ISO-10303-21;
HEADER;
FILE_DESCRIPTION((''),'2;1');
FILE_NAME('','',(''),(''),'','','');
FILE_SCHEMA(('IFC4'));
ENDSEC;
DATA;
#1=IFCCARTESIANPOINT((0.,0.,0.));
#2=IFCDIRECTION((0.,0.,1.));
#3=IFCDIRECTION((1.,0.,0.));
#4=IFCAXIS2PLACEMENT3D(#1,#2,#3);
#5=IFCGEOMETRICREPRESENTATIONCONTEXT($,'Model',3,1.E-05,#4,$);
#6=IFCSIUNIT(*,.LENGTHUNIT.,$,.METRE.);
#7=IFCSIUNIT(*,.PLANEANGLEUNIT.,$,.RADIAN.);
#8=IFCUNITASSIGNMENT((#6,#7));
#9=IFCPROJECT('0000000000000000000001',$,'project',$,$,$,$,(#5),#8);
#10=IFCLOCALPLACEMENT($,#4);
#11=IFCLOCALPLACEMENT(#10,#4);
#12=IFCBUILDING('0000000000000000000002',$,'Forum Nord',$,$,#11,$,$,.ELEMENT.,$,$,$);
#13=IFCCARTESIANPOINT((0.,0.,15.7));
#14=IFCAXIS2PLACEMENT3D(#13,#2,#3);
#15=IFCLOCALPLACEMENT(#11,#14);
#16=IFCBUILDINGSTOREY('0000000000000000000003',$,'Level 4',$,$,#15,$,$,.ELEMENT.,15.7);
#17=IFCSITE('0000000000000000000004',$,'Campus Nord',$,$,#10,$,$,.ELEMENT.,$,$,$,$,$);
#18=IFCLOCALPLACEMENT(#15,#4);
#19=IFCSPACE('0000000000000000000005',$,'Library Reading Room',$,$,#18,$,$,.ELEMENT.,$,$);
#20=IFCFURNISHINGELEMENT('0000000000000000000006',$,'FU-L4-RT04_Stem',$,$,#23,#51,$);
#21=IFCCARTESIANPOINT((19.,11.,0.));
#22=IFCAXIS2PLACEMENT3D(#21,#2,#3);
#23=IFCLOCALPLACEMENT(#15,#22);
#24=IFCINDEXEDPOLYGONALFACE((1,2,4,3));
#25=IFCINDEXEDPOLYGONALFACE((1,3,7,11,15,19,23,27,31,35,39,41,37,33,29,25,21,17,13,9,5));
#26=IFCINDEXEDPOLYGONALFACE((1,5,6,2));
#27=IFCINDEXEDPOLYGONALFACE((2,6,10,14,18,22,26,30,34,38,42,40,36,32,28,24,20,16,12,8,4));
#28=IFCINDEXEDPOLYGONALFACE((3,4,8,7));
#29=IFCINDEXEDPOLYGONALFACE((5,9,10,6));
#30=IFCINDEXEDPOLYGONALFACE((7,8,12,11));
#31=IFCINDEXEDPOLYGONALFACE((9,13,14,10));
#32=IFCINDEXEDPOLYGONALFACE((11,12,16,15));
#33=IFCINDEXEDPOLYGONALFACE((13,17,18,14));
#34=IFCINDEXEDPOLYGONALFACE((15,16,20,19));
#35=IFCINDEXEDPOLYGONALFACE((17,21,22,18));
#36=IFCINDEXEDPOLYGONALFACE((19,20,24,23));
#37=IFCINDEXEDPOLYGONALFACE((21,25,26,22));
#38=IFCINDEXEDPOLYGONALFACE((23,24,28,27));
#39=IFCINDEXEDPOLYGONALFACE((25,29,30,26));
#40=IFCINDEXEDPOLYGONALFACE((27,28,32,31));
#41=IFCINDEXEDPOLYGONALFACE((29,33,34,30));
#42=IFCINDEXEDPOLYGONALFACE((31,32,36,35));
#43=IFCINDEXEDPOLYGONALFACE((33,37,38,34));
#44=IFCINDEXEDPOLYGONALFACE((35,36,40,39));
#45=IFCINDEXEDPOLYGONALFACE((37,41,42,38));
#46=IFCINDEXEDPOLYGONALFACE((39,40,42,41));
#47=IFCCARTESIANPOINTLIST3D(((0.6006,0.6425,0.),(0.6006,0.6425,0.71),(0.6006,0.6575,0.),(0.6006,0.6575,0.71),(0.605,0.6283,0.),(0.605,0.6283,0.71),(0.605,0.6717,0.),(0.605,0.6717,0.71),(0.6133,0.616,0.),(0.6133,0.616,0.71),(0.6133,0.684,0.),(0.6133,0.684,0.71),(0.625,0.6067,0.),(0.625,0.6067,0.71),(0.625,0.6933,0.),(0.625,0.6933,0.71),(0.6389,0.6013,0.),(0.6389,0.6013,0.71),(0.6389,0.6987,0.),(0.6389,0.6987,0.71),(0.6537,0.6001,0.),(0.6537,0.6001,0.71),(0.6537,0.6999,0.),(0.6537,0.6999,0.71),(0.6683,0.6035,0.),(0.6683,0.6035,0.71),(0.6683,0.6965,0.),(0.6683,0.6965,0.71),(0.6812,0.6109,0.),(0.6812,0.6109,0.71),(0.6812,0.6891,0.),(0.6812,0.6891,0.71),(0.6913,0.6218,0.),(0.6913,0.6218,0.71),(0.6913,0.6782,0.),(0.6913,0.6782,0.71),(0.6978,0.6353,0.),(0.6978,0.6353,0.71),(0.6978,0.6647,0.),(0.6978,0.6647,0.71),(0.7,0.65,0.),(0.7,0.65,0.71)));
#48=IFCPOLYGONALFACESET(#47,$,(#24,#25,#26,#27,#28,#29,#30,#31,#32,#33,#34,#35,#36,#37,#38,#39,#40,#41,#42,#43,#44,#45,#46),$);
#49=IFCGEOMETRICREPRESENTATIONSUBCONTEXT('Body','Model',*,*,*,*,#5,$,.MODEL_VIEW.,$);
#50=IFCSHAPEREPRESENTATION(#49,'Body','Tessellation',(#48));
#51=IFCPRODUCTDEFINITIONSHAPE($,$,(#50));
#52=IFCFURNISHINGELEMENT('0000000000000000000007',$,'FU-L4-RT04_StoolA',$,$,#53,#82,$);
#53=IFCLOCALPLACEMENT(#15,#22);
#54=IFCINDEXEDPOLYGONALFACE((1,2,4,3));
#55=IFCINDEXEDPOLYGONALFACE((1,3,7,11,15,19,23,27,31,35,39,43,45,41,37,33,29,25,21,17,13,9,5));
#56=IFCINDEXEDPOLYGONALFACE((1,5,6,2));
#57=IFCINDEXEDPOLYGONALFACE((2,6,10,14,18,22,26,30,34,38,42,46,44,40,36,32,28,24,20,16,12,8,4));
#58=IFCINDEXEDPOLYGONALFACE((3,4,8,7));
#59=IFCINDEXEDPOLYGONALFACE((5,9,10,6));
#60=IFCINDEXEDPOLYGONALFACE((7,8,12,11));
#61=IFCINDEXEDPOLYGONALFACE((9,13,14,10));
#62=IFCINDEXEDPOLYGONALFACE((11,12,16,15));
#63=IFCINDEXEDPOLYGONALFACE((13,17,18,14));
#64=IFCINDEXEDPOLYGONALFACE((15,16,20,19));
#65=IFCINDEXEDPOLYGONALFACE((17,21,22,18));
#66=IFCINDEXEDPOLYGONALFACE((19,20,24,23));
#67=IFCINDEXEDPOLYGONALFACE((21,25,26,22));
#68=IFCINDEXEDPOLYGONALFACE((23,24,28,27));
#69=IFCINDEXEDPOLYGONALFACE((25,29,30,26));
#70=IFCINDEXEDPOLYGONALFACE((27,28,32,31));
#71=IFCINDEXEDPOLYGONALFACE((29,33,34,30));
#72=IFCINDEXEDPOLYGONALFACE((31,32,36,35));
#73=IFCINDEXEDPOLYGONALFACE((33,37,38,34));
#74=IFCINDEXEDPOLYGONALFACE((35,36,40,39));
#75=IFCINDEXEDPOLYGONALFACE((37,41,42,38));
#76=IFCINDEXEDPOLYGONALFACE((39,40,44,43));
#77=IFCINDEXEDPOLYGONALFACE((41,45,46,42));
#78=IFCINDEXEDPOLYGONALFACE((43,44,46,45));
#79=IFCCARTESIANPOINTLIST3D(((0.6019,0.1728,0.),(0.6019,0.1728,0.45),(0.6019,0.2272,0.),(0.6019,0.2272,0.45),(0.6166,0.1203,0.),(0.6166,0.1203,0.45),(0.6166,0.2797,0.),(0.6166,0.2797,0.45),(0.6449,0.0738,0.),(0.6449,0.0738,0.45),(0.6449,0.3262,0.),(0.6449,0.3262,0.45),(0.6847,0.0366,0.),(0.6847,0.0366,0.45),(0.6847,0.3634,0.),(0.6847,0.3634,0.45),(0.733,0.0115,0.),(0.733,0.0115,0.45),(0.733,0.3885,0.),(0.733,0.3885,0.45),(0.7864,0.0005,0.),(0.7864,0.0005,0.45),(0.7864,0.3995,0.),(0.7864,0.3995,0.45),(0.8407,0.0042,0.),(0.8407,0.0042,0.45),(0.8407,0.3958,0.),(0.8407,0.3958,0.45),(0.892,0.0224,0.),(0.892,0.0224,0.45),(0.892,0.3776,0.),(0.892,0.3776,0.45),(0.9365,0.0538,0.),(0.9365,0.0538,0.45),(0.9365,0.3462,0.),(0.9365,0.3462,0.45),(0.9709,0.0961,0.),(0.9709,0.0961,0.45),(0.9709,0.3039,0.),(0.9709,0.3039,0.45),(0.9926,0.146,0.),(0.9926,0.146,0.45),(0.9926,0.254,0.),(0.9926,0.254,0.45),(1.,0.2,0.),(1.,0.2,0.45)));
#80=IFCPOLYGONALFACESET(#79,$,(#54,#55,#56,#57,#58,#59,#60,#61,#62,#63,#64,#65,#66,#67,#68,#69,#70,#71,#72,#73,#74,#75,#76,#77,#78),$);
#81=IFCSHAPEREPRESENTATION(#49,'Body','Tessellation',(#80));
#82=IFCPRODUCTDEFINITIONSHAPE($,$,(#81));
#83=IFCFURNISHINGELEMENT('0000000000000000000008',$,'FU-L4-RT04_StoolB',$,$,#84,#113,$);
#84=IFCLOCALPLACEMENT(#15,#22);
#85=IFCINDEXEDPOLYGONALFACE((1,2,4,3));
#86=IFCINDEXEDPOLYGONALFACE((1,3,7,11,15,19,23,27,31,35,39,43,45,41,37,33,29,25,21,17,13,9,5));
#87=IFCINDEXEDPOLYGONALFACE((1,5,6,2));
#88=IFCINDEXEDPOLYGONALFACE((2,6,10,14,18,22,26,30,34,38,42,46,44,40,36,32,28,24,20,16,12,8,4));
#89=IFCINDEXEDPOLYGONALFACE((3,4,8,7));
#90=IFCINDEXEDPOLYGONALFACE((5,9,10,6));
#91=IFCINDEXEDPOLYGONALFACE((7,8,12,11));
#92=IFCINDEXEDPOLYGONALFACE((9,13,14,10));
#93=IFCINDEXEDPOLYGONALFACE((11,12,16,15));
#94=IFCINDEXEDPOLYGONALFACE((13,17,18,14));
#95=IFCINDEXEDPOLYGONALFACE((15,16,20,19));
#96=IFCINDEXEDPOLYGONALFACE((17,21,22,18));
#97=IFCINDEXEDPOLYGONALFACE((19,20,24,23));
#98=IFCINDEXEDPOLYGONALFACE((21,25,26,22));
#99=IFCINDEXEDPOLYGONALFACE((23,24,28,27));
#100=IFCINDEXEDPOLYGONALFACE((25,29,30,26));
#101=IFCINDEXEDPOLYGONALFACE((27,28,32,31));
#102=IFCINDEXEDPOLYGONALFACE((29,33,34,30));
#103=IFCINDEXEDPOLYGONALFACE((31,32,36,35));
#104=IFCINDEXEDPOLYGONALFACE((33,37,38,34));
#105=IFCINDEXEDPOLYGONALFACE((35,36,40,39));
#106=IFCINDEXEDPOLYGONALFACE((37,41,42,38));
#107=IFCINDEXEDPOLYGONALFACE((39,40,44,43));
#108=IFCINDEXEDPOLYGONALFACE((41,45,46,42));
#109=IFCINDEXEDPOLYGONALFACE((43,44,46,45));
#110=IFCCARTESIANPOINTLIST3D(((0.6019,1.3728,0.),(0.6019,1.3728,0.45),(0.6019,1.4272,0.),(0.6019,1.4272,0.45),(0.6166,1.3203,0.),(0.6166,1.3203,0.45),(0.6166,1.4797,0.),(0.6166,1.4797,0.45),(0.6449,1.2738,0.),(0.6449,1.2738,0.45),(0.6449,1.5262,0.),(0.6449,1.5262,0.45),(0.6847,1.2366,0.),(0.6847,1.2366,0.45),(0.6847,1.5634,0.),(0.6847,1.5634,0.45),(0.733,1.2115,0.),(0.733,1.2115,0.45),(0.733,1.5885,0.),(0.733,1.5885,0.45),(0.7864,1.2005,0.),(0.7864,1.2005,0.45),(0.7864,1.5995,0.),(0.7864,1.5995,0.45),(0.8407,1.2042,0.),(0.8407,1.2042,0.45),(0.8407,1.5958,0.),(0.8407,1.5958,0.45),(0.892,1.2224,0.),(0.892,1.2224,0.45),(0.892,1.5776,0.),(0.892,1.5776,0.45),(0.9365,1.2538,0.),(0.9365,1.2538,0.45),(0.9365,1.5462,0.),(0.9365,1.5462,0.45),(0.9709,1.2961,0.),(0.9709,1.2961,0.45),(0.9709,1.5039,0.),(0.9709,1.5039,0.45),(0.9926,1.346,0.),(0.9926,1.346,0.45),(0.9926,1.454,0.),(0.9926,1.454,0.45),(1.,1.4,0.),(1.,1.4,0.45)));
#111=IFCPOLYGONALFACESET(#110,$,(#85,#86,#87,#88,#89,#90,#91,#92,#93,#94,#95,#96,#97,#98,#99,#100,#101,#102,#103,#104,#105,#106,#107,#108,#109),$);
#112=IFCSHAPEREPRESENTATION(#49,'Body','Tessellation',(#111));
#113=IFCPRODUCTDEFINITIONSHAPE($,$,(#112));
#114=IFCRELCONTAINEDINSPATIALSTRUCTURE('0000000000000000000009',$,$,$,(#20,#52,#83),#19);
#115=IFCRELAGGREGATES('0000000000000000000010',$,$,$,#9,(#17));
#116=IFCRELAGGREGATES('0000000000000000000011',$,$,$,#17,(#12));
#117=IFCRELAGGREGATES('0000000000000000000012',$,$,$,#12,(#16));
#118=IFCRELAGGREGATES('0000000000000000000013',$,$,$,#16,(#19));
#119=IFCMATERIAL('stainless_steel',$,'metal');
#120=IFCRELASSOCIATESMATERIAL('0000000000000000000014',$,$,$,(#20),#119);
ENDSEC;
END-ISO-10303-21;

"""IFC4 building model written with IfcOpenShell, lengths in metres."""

from ifc_helpers import new_model, si_unit, frame, frame_2d, origin_with_axes, place, context, subcontext, project, spatial, circle, extrude, material, element, save


model = new_model("IFC4")

# Units and contexts
model_context = context("Model", 3, precision=1e-05, world=origin_with_axes())
body_context = subcontext(model_context, "Body", "Model", "MODEL_VIEW")
ifc_project = project(units=[si_unit("LENGTHUNIT", "METRE"), si_unit("PLANEANGLEUNIT", "RADIAN")], contexts=[model_context])

# Site, building, storey
site_placement = place(None, origin_with_axes())
site = spatial("IfcSite", under=ifc_project, at=site_placement, Name="Campus Nord", CompositionType="ELEMENT")
building_placement = place(site_placement, origin_with_axes())
building = spatial("IfcBuilding", under=site, at=building_placement, Name="Forum Nord", CompositionType="ELEMENT")
storey_placement = place(building_placement, frame((0.0, 0.0, 15.7), z_axis=(0.0, 0.0, 1.0), x_axis=(1.0, 0.0, 0.0)))
storey = spatial("IfcBuildingStorey", under=building, at=storey_placement, Name="Level 4", CompositionType="ELEMENT", Elevation=15.7)

# Shared definitions
space_1_placement = place(storey_placement, origin_with_axes())
space_1 = spatial("IfcSpace", under=storey, at=space_1_placement, Name="Library Reading Room", CompositionType="ELEMENT")

# Furnishing elements
ifc_material_1 = material(Name="stainless_steel", Category="metal")
furnishing_1_placement = place(storey_placement, frame((19.0, 11.0, 0.0), z_axis=(0.0, 0.0, 1.0), x_axis=(1.0, 0.0, 0.0)))
element("IfcFurnishingElement", 1, at=furnishing_1_placement, inside=space_1, material=ifc_material_1, Name="FU-L4-RT04_Stem", context=body_context, shape_type="SweptSolid", body=[
    extrude(circle(Radius=0.05, at=frame_2d((0.65, 0.65), x_axis=(1.0, 0.0))), origin_with_axes(), (0.0, 0.0, 1.0), 0.71),
])
furnishing_2_placement = place(storey_placement, frame((19.0, 11.0, 0.0), z_axis=(0.0, 0.0, 1.0), x_axis=(1.0, 0.0, 0.0)))
element("IfcFurnishingElement", 2, at=furnishing_2_placement, inside=space_1, Name="FU-L4-RT04_StoolA", context=body_context, shape_type="SweptSolid", body=[
    extrude(circle(Radius=0.2, at=frame_2d((0.8, 0.2), x_axis=(1.0, 0.0))), origin_with_axes(), (0.0, 0.0, 1.0), 0.45),
])
furnishing_3_placement = place(storey_placement, frame((19.0, 11.0, 0.0), z_axis=(0.0, 0.0, 1.0), x_axis=(1.0, 0.0, 0.0)))
element("IfcFurnishingElement", 3, at=furnishing_3_placement, inside=space_1, Name="FU-L4-RT04_StoolB", context=body_context, shape_type="SweptSolid", body=[
    extrude(circle(Radius=0.2, at=frame_2d((0.8, 1.4), x_axis=(1.0, 0.0))), origin_with_axes(), (0.0, 0.0, 1.0), 0.45),
])

save(model, "model.ifc")
